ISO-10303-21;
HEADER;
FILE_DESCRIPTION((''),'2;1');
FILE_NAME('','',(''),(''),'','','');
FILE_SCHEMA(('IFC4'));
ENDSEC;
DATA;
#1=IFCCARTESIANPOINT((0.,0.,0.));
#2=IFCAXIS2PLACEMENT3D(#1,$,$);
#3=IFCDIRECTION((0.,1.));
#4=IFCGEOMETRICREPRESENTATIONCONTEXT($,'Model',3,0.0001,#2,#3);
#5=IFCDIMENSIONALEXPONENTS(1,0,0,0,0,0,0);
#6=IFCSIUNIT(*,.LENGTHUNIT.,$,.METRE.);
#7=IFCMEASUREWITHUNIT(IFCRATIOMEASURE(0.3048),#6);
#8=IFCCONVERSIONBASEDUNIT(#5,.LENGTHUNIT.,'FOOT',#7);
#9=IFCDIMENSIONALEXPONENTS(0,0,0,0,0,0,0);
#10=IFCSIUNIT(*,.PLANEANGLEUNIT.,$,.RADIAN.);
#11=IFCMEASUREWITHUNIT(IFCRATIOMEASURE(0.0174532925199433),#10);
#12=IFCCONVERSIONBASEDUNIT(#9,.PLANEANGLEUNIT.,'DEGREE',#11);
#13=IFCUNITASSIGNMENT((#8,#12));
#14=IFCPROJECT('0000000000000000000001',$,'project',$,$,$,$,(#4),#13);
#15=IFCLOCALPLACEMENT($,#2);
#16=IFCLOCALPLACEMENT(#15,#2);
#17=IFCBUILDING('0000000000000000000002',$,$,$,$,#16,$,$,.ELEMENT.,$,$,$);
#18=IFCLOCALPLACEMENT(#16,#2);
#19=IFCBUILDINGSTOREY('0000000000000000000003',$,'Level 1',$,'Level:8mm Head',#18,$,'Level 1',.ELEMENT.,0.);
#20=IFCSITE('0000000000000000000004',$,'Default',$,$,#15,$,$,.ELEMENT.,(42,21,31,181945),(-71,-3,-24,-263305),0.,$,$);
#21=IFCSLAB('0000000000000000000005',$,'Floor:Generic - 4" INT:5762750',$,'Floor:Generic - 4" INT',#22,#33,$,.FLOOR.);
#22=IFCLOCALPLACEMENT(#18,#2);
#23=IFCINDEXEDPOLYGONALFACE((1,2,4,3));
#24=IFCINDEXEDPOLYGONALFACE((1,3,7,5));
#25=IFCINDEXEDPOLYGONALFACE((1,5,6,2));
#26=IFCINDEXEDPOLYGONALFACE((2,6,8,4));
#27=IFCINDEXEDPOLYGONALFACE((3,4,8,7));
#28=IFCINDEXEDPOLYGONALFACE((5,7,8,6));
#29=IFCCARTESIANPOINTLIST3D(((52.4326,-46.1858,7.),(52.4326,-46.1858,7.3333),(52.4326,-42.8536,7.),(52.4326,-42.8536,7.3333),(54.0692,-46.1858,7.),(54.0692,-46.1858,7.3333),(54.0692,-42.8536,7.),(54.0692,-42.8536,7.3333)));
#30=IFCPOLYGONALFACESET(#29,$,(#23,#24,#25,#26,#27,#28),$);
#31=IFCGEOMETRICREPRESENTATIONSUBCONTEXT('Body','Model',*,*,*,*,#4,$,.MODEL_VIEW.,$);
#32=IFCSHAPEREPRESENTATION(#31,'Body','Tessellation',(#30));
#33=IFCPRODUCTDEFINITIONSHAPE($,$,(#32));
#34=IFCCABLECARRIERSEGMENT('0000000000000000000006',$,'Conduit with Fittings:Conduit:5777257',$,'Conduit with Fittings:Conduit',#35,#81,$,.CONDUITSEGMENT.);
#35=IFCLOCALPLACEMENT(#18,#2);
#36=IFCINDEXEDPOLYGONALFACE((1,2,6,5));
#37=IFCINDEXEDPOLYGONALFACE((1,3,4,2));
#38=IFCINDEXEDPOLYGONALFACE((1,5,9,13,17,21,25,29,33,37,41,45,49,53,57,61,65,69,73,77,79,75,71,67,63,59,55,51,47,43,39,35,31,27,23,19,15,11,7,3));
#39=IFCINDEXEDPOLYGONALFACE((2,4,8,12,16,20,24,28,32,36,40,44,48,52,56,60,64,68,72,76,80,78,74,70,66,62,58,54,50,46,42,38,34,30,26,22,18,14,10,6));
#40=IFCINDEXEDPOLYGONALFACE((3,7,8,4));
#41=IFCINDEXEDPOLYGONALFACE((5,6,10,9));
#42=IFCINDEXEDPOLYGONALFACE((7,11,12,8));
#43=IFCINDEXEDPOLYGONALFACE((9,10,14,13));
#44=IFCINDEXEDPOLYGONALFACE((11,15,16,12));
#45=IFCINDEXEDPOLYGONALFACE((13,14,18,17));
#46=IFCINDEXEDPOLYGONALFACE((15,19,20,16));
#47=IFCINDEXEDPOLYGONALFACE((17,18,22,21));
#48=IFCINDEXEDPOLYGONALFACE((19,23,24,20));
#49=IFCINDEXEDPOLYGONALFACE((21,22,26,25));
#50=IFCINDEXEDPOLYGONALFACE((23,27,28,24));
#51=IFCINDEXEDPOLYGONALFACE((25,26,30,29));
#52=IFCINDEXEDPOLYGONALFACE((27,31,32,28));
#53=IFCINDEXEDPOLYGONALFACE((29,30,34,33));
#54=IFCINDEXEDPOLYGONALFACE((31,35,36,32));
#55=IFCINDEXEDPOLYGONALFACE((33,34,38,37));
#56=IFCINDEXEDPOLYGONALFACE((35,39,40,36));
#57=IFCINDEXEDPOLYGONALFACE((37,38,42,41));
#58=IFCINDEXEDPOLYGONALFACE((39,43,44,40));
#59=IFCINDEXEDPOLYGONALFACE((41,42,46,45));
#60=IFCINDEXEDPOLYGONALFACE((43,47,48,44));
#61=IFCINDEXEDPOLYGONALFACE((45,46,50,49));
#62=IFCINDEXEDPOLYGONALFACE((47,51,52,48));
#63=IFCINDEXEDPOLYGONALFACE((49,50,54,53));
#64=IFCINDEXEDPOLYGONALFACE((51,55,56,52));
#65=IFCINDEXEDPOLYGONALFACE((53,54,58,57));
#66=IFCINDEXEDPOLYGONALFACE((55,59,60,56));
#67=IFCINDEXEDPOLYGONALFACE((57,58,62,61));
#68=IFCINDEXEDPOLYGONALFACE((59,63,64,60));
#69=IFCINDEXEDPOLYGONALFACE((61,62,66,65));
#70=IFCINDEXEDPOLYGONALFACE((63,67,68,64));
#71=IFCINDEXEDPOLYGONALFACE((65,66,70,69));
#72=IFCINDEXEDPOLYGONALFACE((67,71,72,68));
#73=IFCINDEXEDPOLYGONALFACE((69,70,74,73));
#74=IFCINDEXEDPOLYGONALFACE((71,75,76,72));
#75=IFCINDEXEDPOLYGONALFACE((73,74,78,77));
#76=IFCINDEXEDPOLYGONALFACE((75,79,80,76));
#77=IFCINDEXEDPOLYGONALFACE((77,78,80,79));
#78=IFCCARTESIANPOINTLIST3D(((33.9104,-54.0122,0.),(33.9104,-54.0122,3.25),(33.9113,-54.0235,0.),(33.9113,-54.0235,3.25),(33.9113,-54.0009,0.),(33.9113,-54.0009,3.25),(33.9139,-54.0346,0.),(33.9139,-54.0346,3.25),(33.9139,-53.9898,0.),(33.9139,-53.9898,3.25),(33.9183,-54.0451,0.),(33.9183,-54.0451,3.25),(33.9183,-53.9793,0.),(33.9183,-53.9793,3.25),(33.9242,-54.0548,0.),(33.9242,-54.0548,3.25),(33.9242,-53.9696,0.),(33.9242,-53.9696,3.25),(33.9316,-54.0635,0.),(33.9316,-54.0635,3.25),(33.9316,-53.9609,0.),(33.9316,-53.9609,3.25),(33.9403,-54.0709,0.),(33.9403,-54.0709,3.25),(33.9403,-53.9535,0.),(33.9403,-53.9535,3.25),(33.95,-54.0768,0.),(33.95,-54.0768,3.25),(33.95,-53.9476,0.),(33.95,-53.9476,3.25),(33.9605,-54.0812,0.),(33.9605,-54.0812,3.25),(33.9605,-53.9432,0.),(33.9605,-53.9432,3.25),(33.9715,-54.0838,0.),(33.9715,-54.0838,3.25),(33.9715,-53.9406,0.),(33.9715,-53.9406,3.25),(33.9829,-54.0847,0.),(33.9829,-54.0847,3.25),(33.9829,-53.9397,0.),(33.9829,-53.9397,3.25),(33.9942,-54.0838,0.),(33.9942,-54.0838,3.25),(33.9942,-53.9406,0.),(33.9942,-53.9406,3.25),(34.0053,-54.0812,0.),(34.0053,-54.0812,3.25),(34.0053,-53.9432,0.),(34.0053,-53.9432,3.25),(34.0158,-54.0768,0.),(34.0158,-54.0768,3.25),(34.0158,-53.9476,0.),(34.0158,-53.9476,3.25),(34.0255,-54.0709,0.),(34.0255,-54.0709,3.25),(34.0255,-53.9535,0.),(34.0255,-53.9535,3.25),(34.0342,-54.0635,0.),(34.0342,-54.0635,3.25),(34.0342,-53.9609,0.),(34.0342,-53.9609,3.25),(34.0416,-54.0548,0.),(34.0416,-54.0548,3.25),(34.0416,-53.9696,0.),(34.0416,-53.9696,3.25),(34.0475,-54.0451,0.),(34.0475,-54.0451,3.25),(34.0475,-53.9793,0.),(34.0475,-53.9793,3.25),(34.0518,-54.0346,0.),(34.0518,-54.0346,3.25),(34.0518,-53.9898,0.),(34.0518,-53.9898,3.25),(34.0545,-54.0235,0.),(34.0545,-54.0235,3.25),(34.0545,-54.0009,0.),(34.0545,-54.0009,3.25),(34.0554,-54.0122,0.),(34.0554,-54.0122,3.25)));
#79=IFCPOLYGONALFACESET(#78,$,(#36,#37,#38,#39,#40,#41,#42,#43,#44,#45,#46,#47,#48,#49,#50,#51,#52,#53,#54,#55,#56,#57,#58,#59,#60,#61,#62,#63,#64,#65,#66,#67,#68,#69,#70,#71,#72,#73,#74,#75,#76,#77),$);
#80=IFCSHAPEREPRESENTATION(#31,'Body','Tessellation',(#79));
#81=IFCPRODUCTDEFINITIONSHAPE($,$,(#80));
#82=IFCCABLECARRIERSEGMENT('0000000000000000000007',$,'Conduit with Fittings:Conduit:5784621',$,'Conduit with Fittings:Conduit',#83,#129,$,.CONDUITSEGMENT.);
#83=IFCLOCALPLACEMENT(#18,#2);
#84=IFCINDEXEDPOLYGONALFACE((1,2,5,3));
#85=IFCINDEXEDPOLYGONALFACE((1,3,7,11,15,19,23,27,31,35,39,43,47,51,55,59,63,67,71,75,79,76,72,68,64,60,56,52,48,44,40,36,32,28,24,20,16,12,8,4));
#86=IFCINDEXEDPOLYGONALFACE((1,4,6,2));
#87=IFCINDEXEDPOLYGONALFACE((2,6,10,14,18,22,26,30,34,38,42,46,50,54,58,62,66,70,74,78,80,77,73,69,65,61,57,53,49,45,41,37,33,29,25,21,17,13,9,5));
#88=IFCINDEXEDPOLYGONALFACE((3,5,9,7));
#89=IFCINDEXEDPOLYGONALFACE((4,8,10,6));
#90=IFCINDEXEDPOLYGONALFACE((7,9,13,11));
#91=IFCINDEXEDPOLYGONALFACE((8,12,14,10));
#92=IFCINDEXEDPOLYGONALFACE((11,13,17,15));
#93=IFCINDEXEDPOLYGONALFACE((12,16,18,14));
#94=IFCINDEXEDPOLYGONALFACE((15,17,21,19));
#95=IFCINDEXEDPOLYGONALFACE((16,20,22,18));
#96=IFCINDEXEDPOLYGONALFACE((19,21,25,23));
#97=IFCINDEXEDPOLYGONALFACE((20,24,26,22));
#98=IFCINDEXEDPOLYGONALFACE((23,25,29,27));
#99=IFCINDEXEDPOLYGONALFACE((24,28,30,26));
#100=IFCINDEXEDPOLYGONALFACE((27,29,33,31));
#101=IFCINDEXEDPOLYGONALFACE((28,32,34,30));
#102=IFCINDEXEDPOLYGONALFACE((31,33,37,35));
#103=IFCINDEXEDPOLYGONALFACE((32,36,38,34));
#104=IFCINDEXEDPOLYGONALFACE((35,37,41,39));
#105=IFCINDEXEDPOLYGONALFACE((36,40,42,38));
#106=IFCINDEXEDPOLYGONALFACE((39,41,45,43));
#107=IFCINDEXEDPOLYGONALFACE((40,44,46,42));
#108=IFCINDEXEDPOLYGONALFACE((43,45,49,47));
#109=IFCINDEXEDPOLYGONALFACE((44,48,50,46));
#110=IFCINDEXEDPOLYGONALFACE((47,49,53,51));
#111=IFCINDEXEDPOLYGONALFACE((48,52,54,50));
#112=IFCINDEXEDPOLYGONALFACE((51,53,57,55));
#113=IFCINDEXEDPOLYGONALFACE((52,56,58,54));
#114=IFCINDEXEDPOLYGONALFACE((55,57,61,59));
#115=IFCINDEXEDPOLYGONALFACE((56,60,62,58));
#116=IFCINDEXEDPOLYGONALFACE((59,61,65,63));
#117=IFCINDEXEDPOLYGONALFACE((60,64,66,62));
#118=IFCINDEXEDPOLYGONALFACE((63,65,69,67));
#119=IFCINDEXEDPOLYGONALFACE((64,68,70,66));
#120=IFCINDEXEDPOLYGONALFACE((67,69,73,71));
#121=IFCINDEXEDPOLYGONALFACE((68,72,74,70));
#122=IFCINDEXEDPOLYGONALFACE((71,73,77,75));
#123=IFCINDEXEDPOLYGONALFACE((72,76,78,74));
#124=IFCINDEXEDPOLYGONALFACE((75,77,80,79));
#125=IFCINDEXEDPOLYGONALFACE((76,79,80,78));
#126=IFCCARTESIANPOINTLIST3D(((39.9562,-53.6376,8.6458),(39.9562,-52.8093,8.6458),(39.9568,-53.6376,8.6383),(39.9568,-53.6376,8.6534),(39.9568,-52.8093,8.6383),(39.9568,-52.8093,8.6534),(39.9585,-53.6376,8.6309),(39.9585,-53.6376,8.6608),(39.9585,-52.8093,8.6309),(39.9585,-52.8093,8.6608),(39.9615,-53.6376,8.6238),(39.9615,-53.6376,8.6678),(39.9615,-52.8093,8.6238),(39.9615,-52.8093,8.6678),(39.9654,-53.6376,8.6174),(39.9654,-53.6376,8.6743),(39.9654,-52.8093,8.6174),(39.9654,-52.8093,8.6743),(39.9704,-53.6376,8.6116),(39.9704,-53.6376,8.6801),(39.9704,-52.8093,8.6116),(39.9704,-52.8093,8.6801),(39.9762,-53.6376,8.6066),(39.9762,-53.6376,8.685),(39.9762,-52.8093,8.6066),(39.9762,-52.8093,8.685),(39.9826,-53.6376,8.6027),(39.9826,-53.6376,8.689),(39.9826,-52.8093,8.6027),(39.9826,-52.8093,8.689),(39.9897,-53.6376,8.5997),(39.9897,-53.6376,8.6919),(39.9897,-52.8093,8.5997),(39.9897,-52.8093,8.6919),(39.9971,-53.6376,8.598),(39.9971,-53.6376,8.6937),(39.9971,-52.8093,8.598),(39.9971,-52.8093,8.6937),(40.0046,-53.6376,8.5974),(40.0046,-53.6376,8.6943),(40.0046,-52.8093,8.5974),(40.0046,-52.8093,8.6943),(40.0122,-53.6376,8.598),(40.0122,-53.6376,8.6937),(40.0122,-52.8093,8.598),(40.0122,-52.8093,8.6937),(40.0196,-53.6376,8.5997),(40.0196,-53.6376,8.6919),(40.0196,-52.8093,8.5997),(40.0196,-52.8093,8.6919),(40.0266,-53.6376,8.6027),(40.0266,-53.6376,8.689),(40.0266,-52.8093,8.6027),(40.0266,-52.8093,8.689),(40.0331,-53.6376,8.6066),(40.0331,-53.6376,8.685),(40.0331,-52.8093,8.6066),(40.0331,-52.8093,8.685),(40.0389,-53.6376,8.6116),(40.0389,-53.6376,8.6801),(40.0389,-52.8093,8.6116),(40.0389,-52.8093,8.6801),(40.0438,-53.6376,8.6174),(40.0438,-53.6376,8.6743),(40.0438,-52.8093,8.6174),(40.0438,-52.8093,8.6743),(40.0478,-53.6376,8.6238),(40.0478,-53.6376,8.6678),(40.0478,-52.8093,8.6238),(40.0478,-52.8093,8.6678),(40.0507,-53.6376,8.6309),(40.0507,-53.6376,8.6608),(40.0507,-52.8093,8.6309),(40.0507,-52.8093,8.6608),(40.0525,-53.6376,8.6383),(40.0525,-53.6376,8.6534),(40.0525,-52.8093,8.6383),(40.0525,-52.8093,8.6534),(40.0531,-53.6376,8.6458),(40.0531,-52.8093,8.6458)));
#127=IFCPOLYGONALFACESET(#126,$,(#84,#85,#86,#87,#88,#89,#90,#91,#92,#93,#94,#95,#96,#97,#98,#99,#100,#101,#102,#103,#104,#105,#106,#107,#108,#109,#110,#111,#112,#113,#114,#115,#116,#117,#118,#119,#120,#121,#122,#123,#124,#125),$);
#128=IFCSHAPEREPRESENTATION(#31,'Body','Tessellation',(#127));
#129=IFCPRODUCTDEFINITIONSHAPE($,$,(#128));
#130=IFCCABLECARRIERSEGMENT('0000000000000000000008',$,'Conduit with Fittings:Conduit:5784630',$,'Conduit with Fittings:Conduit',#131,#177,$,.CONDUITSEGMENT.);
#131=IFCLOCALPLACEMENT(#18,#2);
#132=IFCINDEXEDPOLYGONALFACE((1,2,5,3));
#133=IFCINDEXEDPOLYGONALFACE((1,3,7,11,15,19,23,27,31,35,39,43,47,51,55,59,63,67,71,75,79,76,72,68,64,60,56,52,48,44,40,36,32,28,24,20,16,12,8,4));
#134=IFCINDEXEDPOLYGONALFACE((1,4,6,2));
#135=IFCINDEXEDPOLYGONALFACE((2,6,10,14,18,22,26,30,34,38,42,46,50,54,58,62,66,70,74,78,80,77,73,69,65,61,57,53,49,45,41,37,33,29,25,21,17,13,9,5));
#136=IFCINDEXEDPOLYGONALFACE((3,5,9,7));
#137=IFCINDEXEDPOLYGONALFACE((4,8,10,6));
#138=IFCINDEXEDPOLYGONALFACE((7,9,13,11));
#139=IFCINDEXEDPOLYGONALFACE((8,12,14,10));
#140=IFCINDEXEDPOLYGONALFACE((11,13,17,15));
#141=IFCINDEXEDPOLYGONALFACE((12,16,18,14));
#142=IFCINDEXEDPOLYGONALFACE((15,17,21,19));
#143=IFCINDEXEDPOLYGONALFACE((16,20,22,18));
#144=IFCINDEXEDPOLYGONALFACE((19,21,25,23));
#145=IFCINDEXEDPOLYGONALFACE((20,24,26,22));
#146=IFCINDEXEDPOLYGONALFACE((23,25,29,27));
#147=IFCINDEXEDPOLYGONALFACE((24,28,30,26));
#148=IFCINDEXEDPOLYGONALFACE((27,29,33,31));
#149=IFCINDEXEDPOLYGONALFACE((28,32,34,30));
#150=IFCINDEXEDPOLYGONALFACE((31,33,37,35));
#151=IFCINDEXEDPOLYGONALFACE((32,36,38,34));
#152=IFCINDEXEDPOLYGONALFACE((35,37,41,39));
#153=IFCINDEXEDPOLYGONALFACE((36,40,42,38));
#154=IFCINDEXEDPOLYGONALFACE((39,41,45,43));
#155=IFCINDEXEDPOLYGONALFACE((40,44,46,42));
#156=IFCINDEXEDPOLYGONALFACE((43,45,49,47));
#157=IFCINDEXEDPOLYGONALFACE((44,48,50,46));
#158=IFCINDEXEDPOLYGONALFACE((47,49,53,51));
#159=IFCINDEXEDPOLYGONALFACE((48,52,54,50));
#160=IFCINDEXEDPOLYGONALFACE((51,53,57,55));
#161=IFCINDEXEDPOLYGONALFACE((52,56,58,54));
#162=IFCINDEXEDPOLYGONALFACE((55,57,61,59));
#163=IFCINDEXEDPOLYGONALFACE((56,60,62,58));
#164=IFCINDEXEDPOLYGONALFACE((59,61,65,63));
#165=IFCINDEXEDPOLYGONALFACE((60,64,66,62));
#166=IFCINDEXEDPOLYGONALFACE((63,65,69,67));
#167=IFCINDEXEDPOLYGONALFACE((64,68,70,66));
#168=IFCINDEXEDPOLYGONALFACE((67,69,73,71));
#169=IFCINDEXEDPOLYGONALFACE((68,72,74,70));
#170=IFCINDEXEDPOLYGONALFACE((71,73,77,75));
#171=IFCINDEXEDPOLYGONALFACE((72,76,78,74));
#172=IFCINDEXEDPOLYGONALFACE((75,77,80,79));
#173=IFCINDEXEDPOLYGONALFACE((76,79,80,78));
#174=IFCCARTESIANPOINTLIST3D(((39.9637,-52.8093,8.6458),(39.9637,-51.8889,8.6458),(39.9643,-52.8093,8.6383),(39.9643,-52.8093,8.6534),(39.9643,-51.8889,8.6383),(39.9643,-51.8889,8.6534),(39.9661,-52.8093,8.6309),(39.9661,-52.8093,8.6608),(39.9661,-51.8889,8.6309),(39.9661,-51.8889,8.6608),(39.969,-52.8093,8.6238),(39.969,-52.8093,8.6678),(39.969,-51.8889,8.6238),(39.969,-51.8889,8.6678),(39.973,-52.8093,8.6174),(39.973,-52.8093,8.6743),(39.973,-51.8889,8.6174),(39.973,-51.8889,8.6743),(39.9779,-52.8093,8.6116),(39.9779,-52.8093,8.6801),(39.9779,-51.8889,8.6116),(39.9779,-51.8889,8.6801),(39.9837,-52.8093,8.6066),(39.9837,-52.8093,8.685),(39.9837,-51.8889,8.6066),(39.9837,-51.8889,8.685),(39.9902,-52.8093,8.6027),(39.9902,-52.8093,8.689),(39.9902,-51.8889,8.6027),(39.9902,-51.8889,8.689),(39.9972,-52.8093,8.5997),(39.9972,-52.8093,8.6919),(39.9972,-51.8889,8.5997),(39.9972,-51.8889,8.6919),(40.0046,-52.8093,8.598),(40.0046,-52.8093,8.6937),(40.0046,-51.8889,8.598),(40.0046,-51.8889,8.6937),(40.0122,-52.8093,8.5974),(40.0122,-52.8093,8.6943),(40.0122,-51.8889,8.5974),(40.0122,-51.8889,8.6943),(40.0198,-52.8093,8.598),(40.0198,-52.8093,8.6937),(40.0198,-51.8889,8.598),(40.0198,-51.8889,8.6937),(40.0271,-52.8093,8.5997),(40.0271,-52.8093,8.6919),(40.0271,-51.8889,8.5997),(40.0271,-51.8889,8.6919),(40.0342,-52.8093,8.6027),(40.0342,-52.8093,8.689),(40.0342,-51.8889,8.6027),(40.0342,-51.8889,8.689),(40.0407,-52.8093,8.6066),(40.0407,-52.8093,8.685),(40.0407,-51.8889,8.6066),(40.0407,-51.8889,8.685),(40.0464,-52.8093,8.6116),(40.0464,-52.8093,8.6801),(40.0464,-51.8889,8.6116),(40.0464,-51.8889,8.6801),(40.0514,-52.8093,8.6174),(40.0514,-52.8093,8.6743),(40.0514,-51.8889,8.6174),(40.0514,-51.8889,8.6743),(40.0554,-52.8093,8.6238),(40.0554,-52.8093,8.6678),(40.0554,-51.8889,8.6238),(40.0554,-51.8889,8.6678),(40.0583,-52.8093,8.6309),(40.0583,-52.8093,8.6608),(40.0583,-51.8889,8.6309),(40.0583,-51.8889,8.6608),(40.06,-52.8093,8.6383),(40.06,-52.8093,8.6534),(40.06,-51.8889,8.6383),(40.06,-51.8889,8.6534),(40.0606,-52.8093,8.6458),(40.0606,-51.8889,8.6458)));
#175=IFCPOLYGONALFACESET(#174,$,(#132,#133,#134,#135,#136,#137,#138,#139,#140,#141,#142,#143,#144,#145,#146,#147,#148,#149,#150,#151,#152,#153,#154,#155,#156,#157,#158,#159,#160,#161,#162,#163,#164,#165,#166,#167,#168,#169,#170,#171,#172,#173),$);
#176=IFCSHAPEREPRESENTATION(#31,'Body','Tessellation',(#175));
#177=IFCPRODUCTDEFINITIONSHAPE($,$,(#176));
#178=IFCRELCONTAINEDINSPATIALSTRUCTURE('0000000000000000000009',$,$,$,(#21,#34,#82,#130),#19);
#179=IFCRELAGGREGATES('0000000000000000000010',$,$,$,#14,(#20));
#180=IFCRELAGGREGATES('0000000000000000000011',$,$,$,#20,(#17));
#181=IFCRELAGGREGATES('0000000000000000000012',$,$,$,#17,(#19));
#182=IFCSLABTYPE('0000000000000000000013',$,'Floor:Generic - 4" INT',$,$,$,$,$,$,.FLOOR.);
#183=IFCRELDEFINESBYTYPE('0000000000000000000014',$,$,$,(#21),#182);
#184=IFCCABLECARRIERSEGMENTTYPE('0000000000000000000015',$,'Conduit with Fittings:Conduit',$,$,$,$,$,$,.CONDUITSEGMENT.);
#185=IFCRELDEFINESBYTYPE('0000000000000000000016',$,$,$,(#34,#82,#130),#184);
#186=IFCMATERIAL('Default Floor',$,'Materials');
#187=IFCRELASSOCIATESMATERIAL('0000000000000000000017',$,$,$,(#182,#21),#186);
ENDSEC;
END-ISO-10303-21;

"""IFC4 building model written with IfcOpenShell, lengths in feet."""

from ifc_helpers import new_model, entity, si_unit, converted_unit, direction, frame, origin, place, context, subcontext, project, spatial, indexed_curve, outline, extrude, material, type_object, element, save


model = new_model("IFC4")

# Units and contexts
model_context = context("Model", 3, precision=0.0001, world=origin(), true_north=direction((0.0, 1.0)))
body_context = subcontext(model_context, "Body", "Model", "MODEL_VIEW")
ifc_project = project(units=[converted_unit("LENGTHUNIT", "FOOT", entity("IfcRatioMeasure", 0.3048), si_unit("LENGTHUNIT", "METRE"), dimensions=[1, 0, 0, 0, 0, 0, 0]), converted_unit("PLANEANGLEUNIT", "DEGREE", entity("IfcRatioMeasure", 0.0174532925199433), si_unit("PLANEANGLEUNIT", "RADIAN"), dimensions=[0, 0, 0, 0, 0, 0, 0])], contexts=[model_context])

# Site, building, storey
site_placement = place(None, origin())
site = spatial("IfcSite", under=ifc_project, at=site_placement, Name="Default", CompositionType="ELEMENT", RefLatitude=(42, 21, 31, 181945), RefLongitude=(-71, -3, -24, -263305), RefElevation=0.0)
building_placement = place(site_placement, origin())
building = spatial("IfcBuilding", under=site, at=building_placement, CompositionType="ELEMENT")
storey_placement = place(building_placement, origin())
storey = spatial("IfcBuildingStorey", under=building, at=storey_placement, Name="Level 1", ObjectType="Level:8mm Head", LongName="Level 1", CompositionType="ELEMENT", Elevation=0.0)

# Slab
ifc_material = material(Name="Default Floor", Category="Materials")
slab_type = type_object("IfcSlabType", Name="Floor:Generic - 4\" INT", PredefinedType="FLOOR", material=ifc_material)
slab_placement = place(storey_placement, origin())
element("IfcSlab", 1, at=slab_placement, inside=storey, type_object=slab_type, material=ifc_material, Name="Floor:Generic - 4\" INT:5762750", ObjectType="Floor:Generic - 4\" INT", PredefinedType="FLOOR", context=body_context, shape_type="SweptSolid", body=[
    extrude(outline(indexed_curve([(-1.6661, -0.8183), (1.6661, -0.8183), (1.6661, 0.8183), (-1.6661, 0.8183), (-1.6661, -0.8183)], self_intersect=False)), frame((53.2509, -44.5197, 7.3333), z_axis=(0.0, 0.0, -1.0), x_axis=(0.0, 1.0, 0.0)), (0.0, 0.0, 1.0), 0.3333),
])

# Cable carrier segments
cable_carrier_segment_type_1 = type_object("IfcCableCarrierSegmentType", Name="Conduit with Fittings:Conduit", PredefinedType="CONDUITSEGMENT")
cable_carrier_segment_1_placement = place(storey_placement, origin())
element("IfcCableCarrierSegment", 2, at=cable_carrier_segment_1_placement, inside=storey, type_object=cable_carrier_segment_type_1, Name="Conduit with Fittings:Conduit:5777257", ObjectType="Conduit with Fittings:Conduit", PredefinedType="CONDUITSEGMENT", context=body_context, shape_type="SweptSolid", body=[
    extrude(outline(indexed_curve([(0.0725, 0.0), (0.0716, 0.0113), (0.069, 0.0224), (0.0646, 0.0329), (0.0587, 0.0426), (0.0513, 0.0513), (0.0426, 0.0587), (0.0329, 0.0646), (0.0224, 0.069), (0.0113, 0.0716), (0.0, 0.0725), (-0.0113, 0.0716), (-0.0224, 0.069), (-0.0329, 0.0646), (-0.0426, 0.0587), (-0.0513, 0.0513), (-0.0587, 0.0426), (-0.0646, 0.0329), (-0.069, 0.0224), (-0.0716, 0.0113), (-0.0725, 0.0), (-0.0716, -0.0113), (-0.069, -0.0224), (-0.0646, -0.0329), (-0.0587, -0.0426), (-0.0513, -0.0513), (-0.0426, -0.0587), (-0.0329, -0.0646), (-0.0224, -0.069), (-0.0113, -0.0716), (0.0, -0.0725), (0.0113, -0.0716), (0.0224, -0.069), (0.0329, -0.0646), (0.0426, -0.0587), (0.0513, -0.0513), (0.0587, -0.0426), (0.0646, -0.0329), (0.069, -0.0224), (0.0716, -0.0113), (0.0725, 0.0)], self_intersect=False)), frame((33.9829, -54.0122, 0.0)), (0.0, 0.0, 1.0), 3.25),
])
cable_carrier_segment_2_placement = place(storey_placement, origin())
element("IfcCableCarrierSegment", 3, at=cable_carrier_segment_2_placement, inside=storey, type_object=cable_carrier_segment_type_1, Name="Conduit with Fittings:Conduit:5784621", ObjectType="Conduit with Fittings:Conduit", PredefinedType="CONDUITSEGMENT", context=body_context, shape_type="SweptSolid", body=[
    extrude(outline(indexed_curve([(0.0485, 0.0), (0.0479, 0.0076), (0.0461, 0.015), (0.0432, 0.022), (0.0392, 0.0285), (0.0343, 0.0343), (0.0285, 0.0392), (0.022, 0.0432), (0.015, 0.0461), (0.0076, 0.0479), (0.0, 0.0485), (-0.0076, 0.0479), (-0.015, 0.0461), (-0.022, 0.0432), (-0.0285, 0.0392), (-0.0343, 0.0343), (-0.0392, 0.0285), (-0.0432, 0.022), (-0.0461, 0.015), (-0.0479, 0.0076), (-0.0485, 0.0), (-0.0479, -0.0076), (-0.0461, -0.015), (-0.0432, -0.022), (-0.0392, -0.0285), (-0.0343, -0.0343), (-0.0285, -0.0392), (-0.022, -0.0432), (-0.015, -0.0461), (-0.0076, -0.0479), (0.0, -0.0485), (0.0076, -0.0479), (0.015, -0.0461), (0.022, -0.0432), (0.0285, -0.0392), (0.0343, -0.0343), (0.0392, -0.0285), (0.0432, -0.022), (0.0461, -0.015), (0.0479, -0.0076), (0.0485, 0.0)], self_intersect=False)), frame((40.0046, -53.6376, 8.6458), z_axis=(0.0, 1.0, 0.0), x_axis=(-1.0, 0.0, 0.0)), (0.0, 0.0, 1.0), 0.8282),
])
cable_carrier_segment_3_placement = place(storey_placement, origin())
element("IfcCableCarrierSegment", 4, at=cable_carrier_segment_3_placement, inside=storey, type_object=cable_carrier_segment_type_1, Name="Conduit with Fittings:Conduit:5784630", ObjectType="Conduit with Fittings:Conduit", PredefinedType="CONDUITSEGMENT", context=body_context, shape_type="SweptSolid", body=[
    extrude(outline(indexed_curve([(0.0485, 0.0), (0.0479, 0.0076), (0.0461, 0.015), (0.0432, 0.022), (0.0392, 0.0285), (0.0343, 0.0343), (0.0285, 0.0392), (0.022, 0.0432), (0.015, 0.0461), (0.0076, 0.0479), (0.0, 0.0485), (-0.0076, 0.0479), (-0.015, 0.0461), (-0.022, 0.0432), (-0.0285, 0.0392), (-0.0343, 0.0343), (-0.0392, 0.0285), (-0.0432, 0.022), (-0.0461, 0.015), (-0.0479, 0.0076), (-0.0485, 0.0), (-0.0479, -0.0076), (-0.0461, -0.015), (-0.0432, -0.022), (-0.0392, -0.0285), (-0.0343, -0.0343), (-0.0285, -0.0392), (-0.022, -0.0432), (-0.015, -0.0461), (-0.0076, -0.0479), (0.0, -0.0485), (0.0076, -0.0479), (0.015, -0.0461), (0.022, -0.0432), (0.0285, -0.0392), (0.0343, -0.0343), (0.0392, -0.0285), (0.0432, -0.022), (0.0461, -0.015), (0.0479, -0.0076), (0.0485, 0.0)], self_intersect=False)), frame((40.0122, -52.8093, 8.6458), z_axis=(0.0, 1.0, 0.0), x_axis=(-1.0, 0.0, 0.0)), (0.0, 0.0, 1.0), 0.9204),
])

save(model, "model.ifc")
